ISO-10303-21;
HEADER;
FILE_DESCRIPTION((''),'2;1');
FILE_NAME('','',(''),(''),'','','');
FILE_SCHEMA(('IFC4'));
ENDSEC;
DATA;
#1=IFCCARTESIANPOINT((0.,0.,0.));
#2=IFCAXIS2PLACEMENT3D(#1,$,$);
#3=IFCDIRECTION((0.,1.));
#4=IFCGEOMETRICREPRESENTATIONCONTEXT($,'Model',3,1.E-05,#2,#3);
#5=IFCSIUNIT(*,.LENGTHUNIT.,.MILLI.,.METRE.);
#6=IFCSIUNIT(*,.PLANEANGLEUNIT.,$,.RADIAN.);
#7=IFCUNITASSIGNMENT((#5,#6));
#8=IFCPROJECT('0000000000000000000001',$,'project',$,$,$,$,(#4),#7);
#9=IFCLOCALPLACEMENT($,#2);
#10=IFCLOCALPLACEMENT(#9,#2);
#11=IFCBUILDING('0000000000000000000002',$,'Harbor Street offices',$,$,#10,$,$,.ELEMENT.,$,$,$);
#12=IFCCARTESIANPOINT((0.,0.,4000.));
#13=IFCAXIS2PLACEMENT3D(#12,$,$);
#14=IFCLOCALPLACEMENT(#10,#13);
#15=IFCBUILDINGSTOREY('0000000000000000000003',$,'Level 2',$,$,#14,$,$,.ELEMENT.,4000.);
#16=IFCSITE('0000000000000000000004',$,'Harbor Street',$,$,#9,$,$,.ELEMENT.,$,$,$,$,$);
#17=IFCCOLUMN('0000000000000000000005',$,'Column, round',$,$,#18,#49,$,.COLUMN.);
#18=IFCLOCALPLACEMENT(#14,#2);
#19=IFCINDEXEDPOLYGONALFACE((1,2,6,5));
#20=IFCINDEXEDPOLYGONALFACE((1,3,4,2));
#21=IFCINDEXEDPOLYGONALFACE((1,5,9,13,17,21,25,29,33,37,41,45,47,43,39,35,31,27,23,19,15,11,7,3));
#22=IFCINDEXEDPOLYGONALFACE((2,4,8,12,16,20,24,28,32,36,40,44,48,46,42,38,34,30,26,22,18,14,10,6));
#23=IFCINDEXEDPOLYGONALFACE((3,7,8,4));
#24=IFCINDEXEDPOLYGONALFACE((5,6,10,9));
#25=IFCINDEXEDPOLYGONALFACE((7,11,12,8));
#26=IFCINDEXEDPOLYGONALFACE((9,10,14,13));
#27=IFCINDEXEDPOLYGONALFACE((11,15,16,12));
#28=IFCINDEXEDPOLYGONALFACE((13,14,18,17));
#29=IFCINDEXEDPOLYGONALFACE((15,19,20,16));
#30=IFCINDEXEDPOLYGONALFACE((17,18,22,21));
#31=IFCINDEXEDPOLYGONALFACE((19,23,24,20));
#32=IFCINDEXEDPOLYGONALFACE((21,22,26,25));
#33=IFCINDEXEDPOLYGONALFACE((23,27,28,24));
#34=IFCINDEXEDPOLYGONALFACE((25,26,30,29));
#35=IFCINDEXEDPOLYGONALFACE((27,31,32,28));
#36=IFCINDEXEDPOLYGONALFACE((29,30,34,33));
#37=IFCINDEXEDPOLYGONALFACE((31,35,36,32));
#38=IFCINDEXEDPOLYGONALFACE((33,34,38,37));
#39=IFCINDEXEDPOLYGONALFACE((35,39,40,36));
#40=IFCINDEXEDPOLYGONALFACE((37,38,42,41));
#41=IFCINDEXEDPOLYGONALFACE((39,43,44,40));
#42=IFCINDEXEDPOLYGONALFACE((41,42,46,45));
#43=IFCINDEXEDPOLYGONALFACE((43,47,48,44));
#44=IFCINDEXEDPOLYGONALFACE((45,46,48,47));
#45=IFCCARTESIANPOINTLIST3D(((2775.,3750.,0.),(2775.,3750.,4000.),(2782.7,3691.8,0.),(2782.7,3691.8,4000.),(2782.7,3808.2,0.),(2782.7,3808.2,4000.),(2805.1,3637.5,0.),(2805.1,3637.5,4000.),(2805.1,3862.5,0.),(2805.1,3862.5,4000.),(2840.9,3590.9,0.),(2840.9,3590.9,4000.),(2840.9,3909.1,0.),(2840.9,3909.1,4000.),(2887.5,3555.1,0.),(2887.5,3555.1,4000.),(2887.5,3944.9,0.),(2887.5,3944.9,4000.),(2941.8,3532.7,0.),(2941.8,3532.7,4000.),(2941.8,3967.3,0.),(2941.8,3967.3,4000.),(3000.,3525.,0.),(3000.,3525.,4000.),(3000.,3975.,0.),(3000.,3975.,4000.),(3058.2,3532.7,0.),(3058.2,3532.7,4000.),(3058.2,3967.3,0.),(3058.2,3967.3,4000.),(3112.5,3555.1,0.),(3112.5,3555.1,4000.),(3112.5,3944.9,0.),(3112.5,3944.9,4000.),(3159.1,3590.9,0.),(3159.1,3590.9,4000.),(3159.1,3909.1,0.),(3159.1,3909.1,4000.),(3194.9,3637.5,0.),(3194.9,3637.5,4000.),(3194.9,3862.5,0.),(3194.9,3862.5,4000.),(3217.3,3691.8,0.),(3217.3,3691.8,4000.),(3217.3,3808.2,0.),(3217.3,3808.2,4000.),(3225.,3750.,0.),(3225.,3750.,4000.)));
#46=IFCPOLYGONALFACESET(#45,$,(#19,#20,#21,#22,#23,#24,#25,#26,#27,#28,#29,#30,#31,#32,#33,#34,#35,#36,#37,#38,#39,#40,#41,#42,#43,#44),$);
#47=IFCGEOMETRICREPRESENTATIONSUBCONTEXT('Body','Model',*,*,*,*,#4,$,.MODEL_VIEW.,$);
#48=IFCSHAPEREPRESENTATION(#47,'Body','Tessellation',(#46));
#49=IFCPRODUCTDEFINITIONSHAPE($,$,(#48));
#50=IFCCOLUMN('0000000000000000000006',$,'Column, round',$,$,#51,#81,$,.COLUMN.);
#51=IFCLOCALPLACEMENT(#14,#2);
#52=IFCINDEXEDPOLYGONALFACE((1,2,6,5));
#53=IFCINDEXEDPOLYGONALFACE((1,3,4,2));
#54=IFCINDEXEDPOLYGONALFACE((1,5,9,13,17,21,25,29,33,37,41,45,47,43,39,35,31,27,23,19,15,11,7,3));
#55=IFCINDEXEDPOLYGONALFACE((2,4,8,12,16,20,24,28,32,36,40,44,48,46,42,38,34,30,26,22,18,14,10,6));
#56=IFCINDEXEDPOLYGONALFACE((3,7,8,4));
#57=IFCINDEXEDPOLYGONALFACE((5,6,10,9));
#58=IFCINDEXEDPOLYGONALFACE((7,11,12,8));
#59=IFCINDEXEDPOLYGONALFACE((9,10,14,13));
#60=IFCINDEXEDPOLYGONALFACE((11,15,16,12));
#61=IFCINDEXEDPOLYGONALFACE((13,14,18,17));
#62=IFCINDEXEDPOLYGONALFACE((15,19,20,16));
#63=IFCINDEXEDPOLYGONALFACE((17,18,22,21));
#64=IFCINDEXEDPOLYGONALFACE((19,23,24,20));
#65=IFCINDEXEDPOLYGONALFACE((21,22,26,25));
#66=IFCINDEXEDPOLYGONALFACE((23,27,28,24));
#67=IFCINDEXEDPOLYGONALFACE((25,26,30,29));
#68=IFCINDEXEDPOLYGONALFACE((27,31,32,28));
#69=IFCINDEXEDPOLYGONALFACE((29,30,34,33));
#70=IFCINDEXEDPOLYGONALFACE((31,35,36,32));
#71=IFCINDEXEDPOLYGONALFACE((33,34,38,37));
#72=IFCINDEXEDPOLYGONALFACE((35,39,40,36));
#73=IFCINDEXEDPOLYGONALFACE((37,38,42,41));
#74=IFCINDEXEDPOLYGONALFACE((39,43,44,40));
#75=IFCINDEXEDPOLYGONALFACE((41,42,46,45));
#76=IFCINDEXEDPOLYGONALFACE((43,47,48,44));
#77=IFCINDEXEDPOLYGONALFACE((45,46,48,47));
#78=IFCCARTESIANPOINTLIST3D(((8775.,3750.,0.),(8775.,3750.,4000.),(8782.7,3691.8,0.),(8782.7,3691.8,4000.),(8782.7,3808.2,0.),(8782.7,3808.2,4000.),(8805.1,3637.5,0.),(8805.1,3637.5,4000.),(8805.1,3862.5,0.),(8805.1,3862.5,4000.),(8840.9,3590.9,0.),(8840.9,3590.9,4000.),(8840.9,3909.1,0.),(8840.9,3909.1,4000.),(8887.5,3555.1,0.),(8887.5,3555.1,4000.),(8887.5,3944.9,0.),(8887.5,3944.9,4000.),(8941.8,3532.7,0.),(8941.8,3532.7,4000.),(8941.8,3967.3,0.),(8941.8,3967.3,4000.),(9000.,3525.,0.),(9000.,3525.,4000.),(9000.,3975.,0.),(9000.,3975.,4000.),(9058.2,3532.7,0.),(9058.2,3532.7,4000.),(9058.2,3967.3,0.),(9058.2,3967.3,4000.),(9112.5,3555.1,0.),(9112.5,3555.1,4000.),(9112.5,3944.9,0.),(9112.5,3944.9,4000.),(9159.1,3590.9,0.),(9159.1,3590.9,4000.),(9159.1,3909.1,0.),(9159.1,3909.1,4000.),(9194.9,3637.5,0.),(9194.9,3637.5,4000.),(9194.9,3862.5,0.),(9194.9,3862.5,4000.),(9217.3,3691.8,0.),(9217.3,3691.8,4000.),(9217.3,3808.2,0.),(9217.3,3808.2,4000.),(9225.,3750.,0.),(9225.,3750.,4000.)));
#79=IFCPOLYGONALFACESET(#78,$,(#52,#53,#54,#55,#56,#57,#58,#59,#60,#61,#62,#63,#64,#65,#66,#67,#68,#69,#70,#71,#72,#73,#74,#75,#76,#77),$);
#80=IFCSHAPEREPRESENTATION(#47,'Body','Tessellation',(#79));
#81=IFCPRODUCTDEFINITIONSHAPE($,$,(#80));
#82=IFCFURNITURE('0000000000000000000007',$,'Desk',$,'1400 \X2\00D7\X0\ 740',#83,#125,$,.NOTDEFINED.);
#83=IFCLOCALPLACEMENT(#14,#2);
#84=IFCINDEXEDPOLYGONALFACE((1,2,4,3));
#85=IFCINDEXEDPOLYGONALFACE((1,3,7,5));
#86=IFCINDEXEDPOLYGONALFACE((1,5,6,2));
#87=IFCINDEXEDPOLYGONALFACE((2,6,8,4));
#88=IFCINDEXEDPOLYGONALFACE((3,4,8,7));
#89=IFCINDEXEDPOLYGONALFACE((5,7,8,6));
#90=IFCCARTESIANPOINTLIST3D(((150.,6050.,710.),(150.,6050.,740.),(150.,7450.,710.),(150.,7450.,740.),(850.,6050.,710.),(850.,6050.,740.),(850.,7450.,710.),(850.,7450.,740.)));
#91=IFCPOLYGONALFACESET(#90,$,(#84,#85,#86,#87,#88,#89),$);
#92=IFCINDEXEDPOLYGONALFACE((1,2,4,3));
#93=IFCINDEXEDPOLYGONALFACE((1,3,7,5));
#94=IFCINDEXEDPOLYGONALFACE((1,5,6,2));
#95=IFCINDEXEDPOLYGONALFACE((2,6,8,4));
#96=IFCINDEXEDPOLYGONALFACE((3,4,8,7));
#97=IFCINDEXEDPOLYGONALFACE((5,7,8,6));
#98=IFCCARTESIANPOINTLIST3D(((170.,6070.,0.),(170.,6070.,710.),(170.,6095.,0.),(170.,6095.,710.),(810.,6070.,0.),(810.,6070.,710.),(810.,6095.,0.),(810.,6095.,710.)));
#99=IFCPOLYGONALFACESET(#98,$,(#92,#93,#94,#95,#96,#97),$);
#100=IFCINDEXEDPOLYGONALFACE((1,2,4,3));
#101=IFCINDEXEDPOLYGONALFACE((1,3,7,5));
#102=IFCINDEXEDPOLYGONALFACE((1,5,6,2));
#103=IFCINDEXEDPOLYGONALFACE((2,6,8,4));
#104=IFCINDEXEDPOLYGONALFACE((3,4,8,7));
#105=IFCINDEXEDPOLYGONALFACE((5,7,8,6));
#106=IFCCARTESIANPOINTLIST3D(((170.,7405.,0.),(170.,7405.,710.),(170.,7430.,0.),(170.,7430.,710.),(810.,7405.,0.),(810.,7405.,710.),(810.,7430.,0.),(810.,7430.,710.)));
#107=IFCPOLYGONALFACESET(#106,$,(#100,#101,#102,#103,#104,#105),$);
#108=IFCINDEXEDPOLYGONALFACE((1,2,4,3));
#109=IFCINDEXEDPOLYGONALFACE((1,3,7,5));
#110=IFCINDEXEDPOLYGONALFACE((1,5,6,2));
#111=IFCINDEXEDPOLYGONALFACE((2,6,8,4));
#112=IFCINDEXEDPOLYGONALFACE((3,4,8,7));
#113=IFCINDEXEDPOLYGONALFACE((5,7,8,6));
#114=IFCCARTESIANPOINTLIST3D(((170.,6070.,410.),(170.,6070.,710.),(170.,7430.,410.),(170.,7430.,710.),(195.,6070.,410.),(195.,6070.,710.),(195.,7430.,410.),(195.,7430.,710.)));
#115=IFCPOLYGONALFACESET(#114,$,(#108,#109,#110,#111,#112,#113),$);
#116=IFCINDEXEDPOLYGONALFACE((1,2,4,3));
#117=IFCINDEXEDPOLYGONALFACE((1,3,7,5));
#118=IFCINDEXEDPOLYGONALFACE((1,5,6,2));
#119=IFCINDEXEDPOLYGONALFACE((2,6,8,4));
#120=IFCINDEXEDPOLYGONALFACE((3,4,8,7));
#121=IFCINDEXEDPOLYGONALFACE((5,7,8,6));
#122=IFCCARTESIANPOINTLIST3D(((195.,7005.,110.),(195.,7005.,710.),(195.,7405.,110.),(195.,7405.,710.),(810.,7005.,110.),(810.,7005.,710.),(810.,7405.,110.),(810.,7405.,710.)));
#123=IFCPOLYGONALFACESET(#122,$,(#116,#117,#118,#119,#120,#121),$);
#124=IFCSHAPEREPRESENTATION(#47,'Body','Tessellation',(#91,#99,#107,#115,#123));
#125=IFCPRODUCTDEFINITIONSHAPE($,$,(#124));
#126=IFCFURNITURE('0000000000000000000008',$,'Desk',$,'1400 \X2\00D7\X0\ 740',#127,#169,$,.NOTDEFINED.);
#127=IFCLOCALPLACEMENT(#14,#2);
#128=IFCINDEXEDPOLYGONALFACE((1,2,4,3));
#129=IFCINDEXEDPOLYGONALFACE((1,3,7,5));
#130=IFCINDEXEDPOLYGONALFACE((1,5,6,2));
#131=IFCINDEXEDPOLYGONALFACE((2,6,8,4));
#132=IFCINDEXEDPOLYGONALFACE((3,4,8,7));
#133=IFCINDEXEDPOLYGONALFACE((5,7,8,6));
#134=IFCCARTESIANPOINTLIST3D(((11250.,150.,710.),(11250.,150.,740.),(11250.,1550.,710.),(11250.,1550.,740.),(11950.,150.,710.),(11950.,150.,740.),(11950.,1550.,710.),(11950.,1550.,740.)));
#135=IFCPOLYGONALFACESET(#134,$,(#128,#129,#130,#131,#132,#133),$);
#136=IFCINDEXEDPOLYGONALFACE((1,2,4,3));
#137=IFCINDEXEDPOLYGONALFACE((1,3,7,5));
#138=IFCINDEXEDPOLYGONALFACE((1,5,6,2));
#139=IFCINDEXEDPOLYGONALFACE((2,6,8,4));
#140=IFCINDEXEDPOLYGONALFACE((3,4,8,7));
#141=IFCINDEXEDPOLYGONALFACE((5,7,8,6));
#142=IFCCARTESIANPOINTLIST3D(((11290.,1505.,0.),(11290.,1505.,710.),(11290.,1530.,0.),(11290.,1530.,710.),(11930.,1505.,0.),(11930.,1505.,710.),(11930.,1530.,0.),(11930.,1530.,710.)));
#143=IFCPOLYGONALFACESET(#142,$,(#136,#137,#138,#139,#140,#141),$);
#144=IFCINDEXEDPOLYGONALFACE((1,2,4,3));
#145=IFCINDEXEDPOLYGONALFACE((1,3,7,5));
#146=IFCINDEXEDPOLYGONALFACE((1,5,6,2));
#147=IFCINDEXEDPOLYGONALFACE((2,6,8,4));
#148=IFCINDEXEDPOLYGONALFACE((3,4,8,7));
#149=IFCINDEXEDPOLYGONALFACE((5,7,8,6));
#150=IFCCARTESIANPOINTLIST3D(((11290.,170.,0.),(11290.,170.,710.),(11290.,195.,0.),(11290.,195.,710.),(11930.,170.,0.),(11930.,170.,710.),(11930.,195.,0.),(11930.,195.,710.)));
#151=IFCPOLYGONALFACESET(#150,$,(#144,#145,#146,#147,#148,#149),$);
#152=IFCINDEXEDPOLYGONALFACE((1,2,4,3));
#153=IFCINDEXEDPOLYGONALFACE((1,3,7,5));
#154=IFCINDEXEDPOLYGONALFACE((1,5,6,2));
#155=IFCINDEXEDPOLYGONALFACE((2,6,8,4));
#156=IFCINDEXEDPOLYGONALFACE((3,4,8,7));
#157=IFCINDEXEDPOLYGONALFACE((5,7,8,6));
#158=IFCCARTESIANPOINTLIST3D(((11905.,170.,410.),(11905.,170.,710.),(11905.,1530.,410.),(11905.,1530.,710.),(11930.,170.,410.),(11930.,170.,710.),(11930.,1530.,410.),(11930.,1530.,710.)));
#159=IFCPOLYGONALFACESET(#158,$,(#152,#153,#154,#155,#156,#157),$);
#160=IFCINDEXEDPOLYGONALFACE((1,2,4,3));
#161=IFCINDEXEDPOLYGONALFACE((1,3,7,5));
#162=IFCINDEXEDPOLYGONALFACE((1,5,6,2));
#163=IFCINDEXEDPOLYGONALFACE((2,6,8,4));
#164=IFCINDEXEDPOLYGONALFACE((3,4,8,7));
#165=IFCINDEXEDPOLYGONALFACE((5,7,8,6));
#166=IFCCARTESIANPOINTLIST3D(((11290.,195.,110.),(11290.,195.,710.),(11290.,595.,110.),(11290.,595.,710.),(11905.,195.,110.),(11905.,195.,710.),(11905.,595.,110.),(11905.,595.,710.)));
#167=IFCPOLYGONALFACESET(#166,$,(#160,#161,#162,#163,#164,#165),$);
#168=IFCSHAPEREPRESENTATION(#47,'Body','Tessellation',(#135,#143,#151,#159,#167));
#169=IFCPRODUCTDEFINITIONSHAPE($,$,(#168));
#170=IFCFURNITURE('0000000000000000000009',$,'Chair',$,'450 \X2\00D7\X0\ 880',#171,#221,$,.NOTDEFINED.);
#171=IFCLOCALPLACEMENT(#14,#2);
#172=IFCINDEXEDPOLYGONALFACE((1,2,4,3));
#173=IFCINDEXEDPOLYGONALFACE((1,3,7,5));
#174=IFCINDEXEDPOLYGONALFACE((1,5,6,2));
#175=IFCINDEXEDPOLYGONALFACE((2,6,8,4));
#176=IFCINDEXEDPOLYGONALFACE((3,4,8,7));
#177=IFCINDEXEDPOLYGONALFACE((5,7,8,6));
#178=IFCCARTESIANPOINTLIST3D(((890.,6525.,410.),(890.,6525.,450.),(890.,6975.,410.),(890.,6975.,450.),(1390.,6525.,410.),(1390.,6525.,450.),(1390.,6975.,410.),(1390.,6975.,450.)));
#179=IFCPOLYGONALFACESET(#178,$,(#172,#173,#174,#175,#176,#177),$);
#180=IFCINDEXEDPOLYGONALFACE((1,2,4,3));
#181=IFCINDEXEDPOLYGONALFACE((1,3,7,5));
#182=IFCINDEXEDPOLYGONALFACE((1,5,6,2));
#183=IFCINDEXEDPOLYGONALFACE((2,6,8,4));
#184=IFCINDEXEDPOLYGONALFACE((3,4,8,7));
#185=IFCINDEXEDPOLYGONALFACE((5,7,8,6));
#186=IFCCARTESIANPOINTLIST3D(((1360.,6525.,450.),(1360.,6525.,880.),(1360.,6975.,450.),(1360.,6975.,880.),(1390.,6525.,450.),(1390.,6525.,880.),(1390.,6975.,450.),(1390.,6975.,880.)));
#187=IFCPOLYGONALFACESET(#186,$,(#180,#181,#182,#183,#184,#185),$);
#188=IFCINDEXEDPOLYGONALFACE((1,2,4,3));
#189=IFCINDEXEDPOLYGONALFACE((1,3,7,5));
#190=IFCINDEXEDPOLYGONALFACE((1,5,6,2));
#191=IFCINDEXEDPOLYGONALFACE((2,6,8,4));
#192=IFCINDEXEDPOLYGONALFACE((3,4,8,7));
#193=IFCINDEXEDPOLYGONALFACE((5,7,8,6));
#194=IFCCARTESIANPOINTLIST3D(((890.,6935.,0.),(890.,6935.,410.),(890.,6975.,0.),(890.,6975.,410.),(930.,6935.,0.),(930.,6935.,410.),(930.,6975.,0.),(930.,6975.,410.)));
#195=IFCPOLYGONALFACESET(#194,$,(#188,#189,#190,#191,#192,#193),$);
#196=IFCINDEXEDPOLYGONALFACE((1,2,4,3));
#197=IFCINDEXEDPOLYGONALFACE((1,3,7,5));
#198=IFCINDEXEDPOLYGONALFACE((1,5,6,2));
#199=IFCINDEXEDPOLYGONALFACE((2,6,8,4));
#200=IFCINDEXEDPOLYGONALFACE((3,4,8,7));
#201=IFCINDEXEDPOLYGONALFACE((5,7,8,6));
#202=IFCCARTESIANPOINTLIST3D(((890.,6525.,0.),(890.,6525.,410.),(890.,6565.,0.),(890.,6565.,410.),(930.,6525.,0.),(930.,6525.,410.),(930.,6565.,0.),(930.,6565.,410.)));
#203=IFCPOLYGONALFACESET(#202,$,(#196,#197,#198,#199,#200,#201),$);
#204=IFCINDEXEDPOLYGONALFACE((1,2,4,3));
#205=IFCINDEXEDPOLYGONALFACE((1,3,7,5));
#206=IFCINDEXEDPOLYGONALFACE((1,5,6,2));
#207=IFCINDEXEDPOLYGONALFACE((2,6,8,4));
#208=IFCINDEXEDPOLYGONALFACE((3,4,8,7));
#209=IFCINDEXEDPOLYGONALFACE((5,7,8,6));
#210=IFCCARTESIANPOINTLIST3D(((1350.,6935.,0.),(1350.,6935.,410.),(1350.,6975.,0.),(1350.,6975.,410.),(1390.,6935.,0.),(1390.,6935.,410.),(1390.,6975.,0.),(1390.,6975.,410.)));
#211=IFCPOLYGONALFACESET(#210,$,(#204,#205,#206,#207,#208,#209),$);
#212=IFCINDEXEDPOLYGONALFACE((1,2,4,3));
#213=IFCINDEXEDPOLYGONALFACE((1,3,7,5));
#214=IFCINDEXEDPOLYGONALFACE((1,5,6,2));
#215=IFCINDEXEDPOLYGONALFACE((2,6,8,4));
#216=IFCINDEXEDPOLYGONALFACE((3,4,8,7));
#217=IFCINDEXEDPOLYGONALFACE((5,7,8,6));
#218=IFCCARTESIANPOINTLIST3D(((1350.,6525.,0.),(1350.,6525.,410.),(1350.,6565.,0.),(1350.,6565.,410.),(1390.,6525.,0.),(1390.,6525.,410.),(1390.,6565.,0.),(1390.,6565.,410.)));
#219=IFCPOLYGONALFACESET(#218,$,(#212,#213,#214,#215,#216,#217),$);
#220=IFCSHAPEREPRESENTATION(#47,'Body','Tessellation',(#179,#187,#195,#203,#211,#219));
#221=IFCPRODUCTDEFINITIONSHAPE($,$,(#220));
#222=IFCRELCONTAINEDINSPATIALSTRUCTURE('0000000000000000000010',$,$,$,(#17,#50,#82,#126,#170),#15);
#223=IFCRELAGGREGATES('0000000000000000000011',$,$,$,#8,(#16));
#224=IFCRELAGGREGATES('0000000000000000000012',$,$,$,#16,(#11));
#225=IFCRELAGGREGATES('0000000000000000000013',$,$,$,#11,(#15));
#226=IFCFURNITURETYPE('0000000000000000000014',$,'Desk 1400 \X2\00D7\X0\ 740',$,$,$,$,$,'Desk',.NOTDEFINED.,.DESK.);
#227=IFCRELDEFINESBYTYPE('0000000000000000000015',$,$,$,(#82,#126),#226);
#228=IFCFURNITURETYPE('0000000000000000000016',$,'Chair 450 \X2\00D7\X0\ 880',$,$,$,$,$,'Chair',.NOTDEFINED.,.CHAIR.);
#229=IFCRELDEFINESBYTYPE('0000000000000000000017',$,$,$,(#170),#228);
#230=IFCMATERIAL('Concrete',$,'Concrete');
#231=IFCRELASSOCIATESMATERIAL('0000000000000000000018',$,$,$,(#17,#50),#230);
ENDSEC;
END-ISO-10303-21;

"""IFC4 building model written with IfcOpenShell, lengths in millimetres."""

from ifc_helpers import new_model, si_unit, direction, frame, origin, origin_2d, place, context, subcontext, project, spatial, polyline, circle, outline, extrude, source, transform, mapped, material, type_object, type_shapes, element, save


model = new_model("IFC4")

# Units and contexts
model_context = context("Model", 3, precision=1e-05, world=origin(), true_north=direction((0.0, 1.0)))
body_context = subcontext(model_context, "Body", "Model", "MODEL_VIEW")
ifc_project = project(units=[si_unit("LENGTHUNIT", "METRE", prefix="MILLI"), si_unit("PLANEANGLEUNIT", "RADIAN")], contexts=[model_context])

# Site, building, storey
site_placement = place(None, origin())
site = spatial("IfcSite", under=ifc_project, at=site_placement, Name="Harbor Street", CompositionType="ELEMENT")
building_placement = place(site_placement, origin())
building = spatial("IfcBuilding", under=site, at=building_placement, Name="Harbor Street offices", CompositionType="ELEMENT")
storey_placement = place(building_placement, frame((0.0, 0.0, 4000.0)))
storey = spatial("IfcBuildingStorey", under=building, at=storey_placement, Name="Level 2", CompositionType="ELEMENT", Elevation=4000.0)

# Columns
ifc_material = material(Name="Concrete", Category="Concrete")
for number, where, z_axis, x_axis, name in (
    (1, (3000.0, 3750.0, 0.0), (0.0, 0.0, 1.0), (1.0, 0.0, 0.0), "Column, round"),
    (2, (9000.0, 3750.0, 0.0), (0.0, 0.0, 1.0), (1.0, 0.0, 0.0), "Column, round"),
):
    element("IfcColumn", number, at=place(storey_placement, frame(where, z_axis=z_axis, x_axis=x_axis)), inside=storey, material=ifc_material, Name=name, PredefinedType="COLUMN", context=body_context, shape_type="SweptSolid", body=[
        extrude(circle(Radius=225.0, at=origin_2d()), origin(), (0.0, 0.0, 1.0), 4000.0),
    ])

# Furniture
furniture_type_1 = type_object("IfcFurnitureType", Name="Desk 1400 × 740", ElementType="Desk", AssemblyPlace="NOTDEFINED", PredefinedType="DESK")
shared_shape_1 = source(origin(), body_context, "Body", "SweptSolid", [
    extrude(outline(polyline([(-700.0, 0.0), (700.0, 0.0), (700.0, 700.0), (-700.0, 700.0), (-700.0, 0.0)])), frame((0.0, 0.0, 710.0)), (0.0, 0.0, 1.0), 30.0),
    extrude(outline(polyline([(-680.0, 40.0), (-655.0, 40.0), (-655.0, 680.0), (-680.0, 680.0), (-680.0, 40.0)])), origin(), (0.0, 0.0, 1.0), 710.0),
    extrude(outline(polyline([(655.0, 40.0), (680.0, 40.0), (680.0, 680.0), (655.0, 680.0), (655.0, 40.0)])), origin(), (0.0, 0.0, 1.0), 710.0),
    extrude(outline(polyline([(-680.0, 655.0), (680.0, 655.0), (680.0, 680.0), (-680.0, 680.0), (-680.0, 655.0)])), frame((0.0, 0.0, 410.0)), (0.0, 0.0, 1.0), 300.0),
    extrude(outline(polyline([(255.0, 40.0), (655.0, 40.0), (655.0, 655.0), (255.0, 655.0), (255.0, 40.0)])), frame((0.0, 0.0, 110.0)), (0.0, 0.0, 1.0), 600.0),
])
type_shapes(furniture_type_1, [shared_shape_1])
for number, where, z_axis, x_axis, name in (
    (3, (850.0, 6750.0, 0.0), (0.0, 0.0, 1.0), (0.0, 1.0, 0.0), "Desk"),
    (4, (11250.0, 850.0, 0.0), (0.0, 0.0, 1.0), (0.0, -1.0, 0.0), "Desk"),
):
    element("IfcFurniture", number, at=place(storey_placement, frame(where, z_axis=z_axis, x_axis=x_axis)), inside=storey, type_object=furniture_type_1, Name=name, ObjectType="1400 × 740", PredefinedType="NOTDEFINED", context=body_context, shape_type="MappedRepresentation", body=[
        mapped(shared_shape_1, transform((0.0, 0.0, 0.0))),
    ])
furniture_type_2 = type_object("IfcFurnitureType", Name="Chair 450 × 880", ElementType="Chair", AssemblyPlace="NOTDEFINED", PredefinedType="CHAIR")
shared_shape_2 = source(origin(), body_context, "Body", "SweptSolid", [
    extrude(outline(polyline([(-225.0, 0.0), (225.0, 0.0), (225.0, 500.0), (-225.0, 500.0), (-225.0, 0.0)])), frame((0.0, 0.0, 410.0)), (0.0, 0.0, 1.0), 40.0),
    extrude(outline(polyline([(-225.0, 470.0), (225.0, 470.0), (225.0, 500.0), (-225.0, 500.0), (-225.0, 470.0)])), frame((0.0, 0.0, 450.0)), (0.0, 0.0, 1.0), 430.0),
    extrude(outline(polyline([(-225.0, 0.0), (-185.0, 0.0), (-185.0, 40.0), (-225.0, 40.0), (-225.0, 0.0)])), origin(), (0.0, 0.0, 1.0), 410.0),
    extrude(outline(polyline([(185.0, 0.0), (225.0, 0.0), (225.0, 40.0), (185.0, 40.0), (185.0, 0.0)])), origin(), (0.0, 0.0, 1.0), 410.0),
    extrude(outline(polyline([(-225.0, 460.0), (-185.0, 460.0), (-185.0, 500.0), (-225.0, 500.0), (-225.0, 460.0)])), origin(), (0.0, 0.0, 1.0), 410.0),
    extrude(outline(polyline([(185.0, 460.0), (225.0, 460.0), (225.0, 500.0), (185.0, 500.0), (185.0, 460.0)])), origin(), (0.0, 0.0, 1.0), 410.0),
])
type_shapes(furniture_type_2, [shared_shape_2])
for number, where, z_axis, x_axis, name in (
    (5, (890.0, 6750.0, 0.0), (0.0, 0.0, 1.0), (0.0, -1.0, 0.0), "Chair"),
):
    element("IfcFurniture", number, at=place(storey_placement, frame(where, z_axis=z_axis, x_axis=x_axis)), inside=storey, type_object=furniture_type_2, Name=name, ObjectType="450 × 880", PredefinedType="NOTDEFINED", context=body_context, shape_type="MappedRepresentation", body=[
        mapped(shared_shape_2, transform((0.0, 0.0, 0.0))),
    ])

save(model, "model.ifc")
